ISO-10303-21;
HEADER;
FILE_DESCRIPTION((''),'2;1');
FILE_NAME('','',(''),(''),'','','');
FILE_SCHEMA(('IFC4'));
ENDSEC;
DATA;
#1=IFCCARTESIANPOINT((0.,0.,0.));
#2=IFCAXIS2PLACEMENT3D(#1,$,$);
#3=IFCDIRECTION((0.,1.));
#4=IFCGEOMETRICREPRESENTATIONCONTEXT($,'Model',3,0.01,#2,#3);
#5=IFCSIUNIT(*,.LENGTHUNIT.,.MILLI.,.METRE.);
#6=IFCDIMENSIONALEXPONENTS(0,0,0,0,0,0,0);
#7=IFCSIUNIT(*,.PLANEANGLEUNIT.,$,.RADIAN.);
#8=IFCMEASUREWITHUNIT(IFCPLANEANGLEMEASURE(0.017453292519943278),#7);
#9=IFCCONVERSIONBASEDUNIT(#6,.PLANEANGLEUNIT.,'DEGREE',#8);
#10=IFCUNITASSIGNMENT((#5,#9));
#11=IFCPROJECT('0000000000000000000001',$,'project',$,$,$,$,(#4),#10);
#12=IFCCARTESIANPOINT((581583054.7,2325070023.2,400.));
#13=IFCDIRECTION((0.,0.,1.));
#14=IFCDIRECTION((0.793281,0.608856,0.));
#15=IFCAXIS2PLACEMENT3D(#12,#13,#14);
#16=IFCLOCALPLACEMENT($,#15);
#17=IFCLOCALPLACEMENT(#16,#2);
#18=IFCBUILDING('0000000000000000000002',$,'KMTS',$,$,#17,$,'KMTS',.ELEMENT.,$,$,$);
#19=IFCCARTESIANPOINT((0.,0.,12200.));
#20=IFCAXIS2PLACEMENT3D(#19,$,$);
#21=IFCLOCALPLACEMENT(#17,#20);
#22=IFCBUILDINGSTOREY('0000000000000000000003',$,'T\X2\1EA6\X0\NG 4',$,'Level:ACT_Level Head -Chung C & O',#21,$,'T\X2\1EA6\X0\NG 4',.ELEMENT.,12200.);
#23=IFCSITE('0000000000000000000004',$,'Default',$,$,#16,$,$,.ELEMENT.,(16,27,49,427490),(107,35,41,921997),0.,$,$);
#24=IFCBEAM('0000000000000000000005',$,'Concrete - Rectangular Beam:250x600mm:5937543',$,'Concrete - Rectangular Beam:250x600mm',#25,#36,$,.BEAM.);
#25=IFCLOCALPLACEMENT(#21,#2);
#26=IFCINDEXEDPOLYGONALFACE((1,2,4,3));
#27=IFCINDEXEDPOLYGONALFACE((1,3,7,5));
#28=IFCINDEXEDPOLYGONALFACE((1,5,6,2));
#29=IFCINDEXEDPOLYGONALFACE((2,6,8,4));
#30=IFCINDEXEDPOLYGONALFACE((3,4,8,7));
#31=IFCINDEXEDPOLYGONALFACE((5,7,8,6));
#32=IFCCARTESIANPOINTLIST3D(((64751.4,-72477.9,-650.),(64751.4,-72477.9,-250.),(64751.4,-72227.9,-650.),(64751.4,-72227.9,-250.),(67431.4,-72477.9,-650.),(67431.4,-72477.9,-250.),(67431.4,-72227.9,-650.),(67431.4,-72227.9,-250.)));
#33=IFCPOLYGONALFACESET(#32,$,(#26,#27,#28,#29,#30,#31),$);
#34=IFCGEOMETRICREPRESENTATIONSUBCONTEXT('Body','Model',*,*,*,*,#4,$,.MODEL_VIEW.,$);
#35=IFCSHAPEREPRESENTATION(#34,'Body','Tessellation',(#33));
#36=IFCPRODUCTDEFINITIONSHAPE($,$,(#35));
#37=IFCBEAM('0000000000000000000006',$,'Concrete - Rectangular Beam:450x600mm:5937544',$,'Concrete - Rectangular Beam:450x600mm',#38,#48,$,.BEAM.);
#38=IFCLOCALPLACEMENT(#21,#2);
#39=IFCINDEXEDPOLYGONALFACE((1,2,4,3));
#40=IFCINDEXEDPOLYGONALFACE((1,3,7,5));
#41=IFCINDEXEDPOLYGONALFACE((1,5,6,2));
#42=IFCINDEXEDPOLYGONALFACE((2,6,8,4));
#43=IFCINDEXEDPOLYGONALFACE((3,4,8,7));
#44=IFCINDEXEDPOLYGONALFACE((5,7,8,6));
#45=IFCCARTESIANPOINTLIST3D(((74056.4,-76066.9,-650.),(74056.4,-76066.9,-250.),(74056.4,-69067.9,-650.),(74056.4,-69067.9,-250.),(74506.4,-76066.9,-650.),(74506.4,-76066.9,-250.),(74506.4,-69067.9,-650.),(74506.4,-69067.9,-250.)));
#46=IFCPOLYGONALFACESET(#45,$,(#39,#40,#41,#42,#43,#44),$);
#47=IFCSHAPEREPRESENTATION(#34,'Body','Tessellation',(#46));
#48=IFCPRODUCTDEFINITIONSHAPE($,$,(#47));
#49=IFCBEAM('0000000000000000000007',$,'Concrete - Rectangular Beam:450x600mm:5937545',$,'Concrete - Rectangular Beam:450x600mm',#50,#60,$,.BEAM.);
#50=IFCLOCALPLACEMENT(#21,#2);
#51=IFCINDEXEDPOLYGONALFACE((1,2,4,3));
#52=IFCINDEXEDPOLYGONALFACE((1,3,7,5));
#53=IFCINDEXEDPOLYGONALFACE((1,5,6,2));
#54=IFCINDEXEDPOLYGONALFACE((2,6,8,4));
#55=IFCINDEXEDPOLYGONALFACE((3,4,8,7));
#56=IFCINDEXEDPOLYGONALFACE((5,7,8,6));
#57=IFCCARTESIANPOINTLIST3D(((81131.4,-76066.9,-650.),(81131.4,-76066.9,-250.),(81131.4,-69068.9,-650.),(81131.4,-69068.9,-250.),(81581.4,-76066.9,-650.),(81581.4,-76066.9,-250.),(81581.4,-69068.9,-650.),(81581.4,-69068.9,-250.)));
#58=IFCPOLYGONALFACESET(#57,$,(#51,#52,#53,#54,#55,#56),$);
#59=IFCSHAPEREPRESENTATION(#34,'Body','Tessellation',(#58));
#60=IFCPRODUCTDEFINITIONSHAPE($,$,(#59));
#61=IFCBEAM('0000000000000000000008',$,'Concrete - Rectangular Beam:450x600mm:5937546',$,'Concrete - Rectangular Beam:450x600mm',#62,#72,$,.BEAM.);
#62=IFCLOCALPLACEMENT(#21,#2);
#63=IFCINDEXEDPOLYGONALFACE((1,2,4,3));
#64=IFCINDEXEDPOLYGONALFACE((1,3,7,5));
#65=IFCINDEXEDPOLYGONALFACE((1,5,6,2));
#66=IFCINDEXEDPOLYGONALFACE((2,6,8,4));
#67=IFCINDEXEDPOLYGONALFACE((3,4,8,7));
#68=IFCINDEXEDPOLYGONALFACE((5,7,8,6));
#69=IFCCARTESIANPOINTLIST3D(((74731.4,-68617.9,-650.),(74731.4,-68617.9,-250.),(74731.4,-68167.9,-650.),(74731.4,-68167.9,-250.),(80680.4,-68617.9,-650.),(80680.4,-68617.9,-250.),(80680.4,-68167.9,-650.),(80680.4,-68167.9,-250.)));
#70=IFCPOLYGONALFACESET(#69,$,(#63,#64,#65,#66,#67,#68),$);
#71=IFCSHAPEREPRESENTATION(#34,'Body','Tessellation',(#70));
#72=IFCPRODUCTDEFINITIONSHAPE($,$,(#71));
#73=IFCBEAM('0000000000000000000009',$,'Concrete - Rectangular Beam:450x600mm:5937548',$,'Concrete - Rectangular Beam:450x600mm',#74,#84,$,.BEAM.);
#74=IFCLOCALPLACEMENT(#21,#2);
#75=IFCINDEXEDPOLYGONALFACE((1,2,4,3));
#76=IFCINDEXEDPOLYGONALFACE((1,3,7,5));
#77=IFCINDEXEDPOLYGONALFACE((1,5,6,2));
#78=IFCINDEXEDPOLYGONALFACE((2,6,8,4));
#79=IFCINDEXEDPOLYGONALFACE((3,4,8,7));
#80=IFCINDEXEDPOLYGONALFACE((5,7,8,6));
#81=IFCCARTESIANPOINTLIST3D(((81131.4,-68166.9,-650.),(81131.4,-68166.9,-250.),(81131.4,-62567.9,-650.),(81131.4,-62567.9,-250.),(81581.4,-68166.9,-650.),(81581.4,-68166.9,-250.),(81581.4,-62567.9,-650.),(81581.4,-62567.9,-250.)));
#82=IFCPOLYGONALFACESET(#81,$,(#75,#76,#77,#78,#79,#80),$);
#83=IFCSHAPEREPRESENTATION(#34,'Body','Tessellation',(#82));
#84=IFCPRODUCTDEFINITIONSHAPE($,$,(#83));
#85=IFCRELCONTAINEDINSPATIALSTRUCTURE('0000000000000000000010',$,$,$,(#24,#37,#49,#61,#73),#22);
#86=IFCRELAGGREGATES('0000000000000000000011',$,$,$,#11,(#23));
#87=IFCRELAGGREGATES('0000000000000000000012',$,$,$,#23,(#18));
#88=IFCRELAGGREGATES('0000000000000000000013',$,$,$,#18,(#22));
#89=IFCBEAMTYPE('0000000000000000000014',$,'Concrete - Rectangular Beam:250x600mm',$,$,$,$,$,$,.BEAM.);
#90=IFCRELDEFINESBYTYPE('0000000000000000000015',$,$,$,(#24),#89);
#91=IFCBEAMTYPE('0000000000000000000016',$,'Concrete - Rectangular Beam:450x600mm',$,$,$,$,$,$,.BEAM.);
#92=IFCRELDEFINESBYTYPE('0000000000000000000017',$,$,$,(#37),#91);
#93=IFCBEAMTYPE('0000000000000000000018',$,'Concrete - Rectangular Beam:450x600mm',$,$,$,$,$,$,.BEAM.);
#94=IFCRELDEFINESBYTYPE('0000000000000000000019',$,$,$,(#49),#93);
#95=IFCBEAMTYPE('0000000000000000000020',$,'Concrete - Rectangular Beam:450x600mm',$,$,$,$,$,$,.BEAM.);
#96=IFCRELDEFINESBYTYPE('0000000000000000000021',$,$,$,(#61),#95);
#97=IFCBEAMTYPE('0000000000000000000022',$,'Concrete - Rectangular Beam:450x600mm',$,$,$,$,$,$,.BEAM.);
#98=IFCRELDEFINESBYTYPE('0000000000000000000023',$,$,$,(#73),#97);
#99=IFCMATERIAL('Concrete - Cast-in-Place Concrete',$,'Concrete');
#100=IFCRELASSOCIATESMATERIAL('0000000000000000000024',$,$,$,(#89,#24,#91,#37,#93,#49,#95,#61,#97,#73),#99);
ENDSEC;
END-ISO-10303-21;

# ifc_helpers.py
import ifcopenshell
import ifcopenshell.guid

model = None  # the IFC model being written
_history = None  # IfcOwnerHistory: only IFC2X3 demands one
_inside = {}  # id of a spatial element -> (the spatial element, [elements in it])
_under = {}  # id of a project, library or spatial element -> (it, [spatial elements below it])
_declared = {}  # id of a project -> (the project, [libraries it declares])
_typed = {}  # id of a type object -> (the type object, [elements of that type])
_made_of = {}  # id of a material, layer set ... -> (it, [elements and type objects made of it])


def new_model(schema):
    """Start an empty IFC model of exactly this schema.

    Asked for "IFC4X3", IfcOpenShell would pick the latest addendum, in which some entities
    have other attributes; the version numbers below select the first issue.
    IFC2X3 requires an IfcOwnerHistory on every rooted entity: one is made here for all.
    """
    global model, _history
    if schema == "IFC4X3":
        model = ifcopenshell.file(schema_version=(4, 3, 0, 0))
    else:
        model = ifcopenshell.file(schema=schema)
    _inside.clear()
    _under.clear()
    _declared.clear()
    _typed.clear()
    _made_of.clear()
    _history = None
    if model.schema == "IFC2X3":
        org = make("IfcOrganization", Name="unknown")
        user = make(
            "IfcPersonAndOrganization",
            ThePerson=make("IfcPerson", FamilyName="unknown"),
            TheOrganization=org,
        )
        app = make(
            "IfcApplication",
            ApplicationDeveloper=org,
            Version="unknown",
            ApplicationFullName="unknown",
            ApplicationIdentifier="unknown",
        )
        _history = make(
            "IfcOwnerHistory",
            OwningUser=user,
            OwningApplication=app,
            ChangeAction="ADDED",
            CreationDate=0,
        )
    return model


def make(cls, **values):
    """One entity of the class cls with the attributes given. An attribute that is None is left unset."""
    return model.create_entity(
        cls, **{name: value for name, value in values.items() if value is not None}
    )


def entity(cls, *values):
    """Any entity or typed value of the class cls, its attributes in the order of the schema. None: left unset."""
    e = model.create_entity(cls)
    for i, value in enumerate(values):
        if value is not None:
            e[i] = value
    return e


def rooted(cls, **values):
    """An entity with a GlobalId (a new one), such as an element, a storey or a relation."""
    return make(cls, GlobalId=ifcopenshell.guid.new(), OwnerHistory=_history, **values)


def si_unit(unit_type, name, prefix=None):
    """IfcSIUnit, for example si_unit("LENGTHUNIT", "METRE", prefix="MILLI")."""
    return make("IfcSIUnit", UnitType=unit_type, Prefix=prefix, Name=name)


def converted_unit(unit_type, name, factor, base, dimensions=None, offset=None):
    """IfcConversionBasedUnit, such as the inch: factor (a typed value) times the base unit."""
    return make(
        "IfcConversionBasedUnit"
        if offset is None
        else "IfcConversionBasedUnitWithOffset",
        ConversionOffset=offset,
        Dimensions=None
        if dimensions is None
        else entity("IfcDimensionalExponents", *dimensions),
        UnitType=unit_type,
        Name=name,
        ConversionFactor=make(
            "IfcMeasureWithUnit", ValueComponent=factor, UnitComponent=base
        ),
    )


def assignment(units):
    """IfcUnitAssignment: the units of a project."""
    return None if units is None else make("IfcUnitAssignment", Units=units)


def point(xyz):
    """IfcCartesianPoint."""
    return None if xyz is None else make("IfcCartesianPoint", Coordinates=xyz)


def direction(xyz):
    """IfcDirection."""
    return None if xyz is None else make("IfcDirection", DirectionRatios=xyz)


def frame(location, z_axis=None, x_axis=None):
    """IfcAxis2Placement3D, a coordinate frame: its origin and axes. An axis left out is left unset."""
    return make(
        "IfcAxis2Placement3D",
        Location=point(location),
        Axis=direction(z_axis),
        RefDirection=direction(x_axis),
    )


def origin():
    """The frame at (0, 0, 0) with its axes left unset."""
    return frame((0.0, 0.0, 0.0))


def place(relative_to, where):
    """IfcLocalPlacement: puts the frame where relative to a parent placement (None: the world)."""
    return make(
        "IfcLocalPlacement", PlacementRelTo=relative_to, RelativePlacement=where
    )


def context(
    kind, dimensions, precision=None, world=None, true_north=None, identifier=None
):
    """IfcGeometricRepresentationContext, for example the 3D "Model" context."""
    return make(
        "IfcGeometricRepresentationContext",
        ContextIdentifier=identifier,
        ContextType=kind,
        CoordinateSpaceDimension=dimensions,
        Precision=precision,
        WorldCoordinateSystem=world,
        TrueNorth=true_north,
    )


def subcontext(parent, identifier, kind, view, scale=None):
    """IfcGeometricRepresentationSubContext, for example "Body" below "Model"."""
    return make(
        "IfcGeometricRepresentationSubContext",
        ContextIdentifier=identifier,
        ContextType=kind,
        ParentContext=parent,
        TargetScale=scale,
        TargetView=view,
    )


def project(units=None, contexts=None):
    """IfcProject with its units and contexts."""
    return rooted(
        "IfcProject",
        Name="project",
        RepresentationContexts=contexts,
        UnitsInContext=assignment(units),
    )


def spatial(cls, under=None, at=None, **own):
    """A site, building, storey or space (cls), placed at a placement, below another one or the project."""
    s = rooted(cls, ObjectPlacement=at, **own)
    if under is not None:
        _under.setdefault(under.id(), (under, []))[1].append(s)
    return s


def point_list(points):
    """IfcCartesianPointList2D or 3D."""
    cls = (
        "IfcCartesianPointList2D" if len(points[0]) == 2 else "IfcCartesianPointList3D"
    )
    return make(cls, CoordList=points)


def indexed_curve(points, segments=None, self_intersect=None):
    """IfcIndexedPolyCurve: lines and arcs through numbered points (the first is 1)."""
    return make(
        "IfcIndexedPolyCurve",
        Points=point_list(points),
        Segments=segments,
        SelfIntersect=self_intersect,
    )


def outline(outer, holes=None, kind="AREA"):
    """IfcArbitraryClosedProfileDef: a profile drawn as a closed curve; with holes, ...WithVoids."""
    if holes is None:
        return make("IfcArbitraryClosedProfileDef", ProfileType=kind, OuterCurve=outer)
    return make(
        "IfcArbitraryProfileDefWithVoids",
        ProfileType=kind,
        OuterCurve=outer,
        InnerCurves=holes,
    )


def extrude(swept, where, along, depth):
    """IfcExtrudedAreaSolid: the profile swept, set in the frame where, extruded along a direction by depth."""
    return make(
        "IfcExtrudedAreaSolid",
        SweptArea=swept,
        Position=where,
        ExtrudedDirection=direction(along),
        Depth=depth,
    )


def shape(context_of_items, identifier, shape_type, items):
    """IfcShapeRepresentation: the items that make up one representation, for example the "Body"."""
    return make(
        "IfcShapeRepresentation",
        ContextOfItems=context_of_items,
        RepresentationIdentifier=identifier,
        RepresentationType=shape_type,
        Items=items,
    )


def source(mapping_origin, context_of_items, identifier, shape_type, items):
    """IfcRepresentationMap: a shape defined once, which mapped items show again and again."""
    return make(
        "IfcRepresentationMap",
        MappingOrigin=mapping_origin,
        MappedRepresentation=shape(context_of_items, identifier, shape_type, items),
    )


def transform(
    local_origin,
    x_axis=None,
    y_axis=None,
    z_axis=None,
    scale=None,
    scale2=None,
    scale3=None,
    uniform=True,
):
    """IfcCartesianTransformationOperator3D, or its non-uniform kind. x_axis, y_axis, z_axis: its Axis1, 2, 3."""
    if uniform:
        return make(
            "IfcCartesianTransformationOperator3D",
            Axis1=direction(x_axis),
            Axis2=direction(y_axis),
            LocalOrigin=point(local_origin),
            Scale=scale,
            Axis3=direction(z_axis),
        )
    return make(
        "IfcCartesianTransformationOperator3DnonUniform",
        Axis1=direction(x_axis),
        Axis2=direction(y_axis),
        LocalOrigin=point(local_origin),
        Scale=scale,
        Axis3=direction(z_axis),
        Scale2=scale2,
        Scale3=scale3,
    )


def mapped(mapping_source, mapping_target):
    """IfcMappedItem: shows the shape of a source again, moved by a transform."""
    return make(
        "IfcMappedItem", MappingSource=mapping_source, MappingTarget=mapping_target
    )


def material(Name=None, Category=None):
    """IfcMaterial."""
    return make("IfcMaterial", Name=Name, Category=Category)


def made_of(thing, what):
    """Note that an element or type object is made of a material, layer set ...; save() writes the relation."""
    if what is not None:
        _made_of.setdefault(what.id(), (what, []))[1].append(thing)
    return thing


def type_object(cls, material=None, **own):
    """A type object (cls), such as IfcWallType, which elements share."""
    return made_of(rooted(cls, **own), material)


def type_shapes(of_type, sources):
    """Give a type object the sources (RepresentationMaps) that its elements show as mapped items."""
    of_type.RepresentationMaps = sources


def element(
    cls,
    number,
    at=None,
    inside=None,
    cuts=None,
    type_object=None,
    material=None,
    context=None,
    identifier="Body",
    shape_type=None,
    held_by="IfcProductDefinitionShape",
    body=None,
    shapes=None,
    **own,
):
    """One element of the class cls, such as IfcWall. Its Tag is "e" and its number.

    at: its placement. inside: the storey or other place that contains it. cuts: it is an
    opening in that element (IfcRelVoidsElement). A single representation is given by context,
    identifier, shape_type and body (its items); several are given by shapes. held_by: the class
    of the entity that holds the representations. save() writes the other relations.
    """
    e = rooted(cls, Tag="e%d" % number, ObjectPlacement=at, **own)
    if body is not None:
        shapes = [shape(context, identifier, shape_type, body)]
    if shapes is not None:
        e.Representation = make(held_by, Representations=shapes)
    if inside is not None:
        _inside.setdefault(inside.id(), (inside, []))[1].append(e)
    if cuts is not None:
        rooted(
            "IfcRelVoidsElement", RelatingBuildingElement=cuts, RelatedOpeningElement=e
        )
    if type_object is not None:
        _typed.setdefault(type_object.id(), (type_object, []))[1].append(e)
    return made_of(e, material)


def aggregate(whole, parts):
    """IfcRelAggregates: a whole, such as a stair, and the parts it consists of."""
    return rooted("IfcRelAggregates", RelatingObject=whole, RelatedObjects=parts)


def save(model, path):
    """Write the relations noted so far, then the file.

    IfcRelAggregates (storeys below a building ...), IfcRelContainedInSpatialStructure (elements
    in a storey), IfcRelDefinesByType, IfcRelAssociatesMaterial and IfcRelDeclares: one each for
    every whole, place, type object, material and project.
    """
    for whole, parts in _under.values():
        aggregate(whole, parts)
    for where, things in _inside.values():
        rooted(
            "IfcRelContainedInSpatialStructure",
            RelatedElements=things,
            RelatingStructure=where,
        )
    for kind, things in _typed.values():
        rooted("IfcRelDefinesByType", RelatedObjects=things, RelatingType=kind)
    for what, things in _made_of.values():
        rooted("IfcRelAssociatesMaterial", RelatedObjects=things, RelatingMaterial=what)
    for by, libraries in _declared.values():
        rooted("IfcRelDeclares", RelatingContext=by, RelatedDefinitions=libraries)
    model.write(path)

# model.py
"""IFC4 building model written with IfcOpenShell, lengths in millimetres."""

from ifc_helpers import new_model, entity, si_unit, converted_unit, direction, frame, origin, place, context, subcontext, project, spatial, indexed_curve, outline, extrude, source, transform, mapped, material, type_object, type_shapes, element, save


model = new_model("IFC4")

# Units and contexts
model_context = context("Model", 3, precision=0.01, world=origin(), true_north=direction((0.0, 1.0)))
body_context = subcontext(model_context, "Body", "Model", "MODEL_VIEW")
ifc_project = project(units=[si_unit("LENGTHUNIT", "METRE", prefix="MILLI"), converted_unit("PLANEANGLEUNIT", "DEGREE", entity("IfcPlaneAngleMeasure", 0.017453292519943278), si_unit("PLANEANGLEUNIT", "RADIAN"), dimensions=[0, 0, 0, 0, 0, 0, 0])], contexts=[model_context])

# Site, building, storey
site_placement = place(None, frame((581583054.7, 2325070023.2, 400.0), z_axis=(0.0, 0.0, 1.0), x_axis=(0.793281, 0.608856, 0.0)))
site = spatial("IfcSite", under=ifc_project, at=site_placement, Name="Default", CompositionType="ELEMENT", RefLatitude=(16, 27, 49, 427490), RefLongitude=(107, 35, 41, 921997), RefElevation=0.0)
building_placement = place(site_placement, origin())
building = spatial("IfcBuilding", under=site, at=building_placement, Name="KMTS", LongName="KMTS", CompositionType="ELEMENT")
storey_placement = place(building_placement, frame((0.0, 0.0, 12200.0)))
storey = spatial("IfcBuildingStorey", under=building, at=storey_placement, Name="TẦNG 4", ObjectType="Level:ACT_Level Head -Chung C & O", LongName="TẦNG 4", CompositionType="ELEMENT", Elevation=12200.0)

# Beams
ifc_material_1 = material(Name="Concrete - Cast-in-Place Concrete", Category="Concrete")
beam_type_1 = type_object("IfcBeamType", Name="Concrete - Rectangular Beam:250x600mm", PredefinedType="BEAM", material=ifc_material_1)
shared_shape_1 = source(origin(), body_context, "Body", "SweptSolid", [
    extrude(outline(indexed_curve([(-200.0, -125.0), (200.0, -125.0), (200.0, 125.0), (-200.0, 125.0), (-200.0, -125.0)], self_intersect=False)), frame((64751.4, -72352.9, 11750.0), z_axis=(1.0, 0.0, 0.0), x_axis=(0.0, 0.0, -1.0)), (0.0, 0.0, 1.0), 2680.0),
])
type_shapes(beam_type_1, [shared_shape_1])
beam_1_placement = place(storey_placement, frame((0.0, 0.0, -12200.0)))
element("IfcBeam", 1, at=beam_1_placement, inside=storey, type_object=beam_type_1, material=ifc_material_1, Name="Concrete - Rectangular Beam:250x600mm:5937543", ObjectType="Concrete - Rectangular Beam:250x600mm", PredefinedType="BEAM", context=body_context, shape_type="MappedRepresentation", body=[
    mapped(shared_shape_1, transform((0.0, 0.0, 0.0), scale=1.0)),
])
beam_type_2 = type_object("IfcBeamType", Name="Concrete - Rectangular Beam:450x600mm", PredefinedType="BEAM", material=ifc_material_1)
shared_shape_2 = source(origin(), body_context, "Body", "SweptSolid", [
    extrude(outline(indexed_curve([(-225.0, -200.0), (225.0, -200.0), (225.0, 200.0), (-225.0, 200.0), (-225.0, -200.0)], self_intersect=False)), frame((74281.4, -76066.9, 11750.0), z_axis=(0.0, 1.0, 0.0), x_axis=(-1.0, 0.0, 0.0)), (0.0, 0.0, 1.0), 6999.0),
])
type_shapes(beam_type_2, [shared_shape_2])
beam_2_placement = place(storey_placement, frame((0.0, 0.0, -12200.0)))
element("IfcBeam", 2, at=beam_2_placement, inside=storey, type_object=beam_type_2, material=ifc_material_1, Name="Concrete - Rectangular Beam:450x600mm:5937544", ObjectType="Concrete - Rectangular Beam:450x600mm", PredefinedType="BEAM", context=body_context, shape_type="MappedRepresentation", body=[
    mapped(shared_shape_2, transform((0.0, 0.0, 0.0), scale=1.0)),
])
beam_type_3 = type_object("IfcBeamType", Name="Concrete - Rectangular Beam:450x600mm", PredefinedType="BEAM", material=ifc_material_1)
shared_shape_3 = source(origin(), body_context, "Body", "SweptSolid", [
    extrude(outline(indexed_curve([(-225.0, -200.0), (225.0, -200.0), (225.0, 200.0), (-225.0, 200.0), (-225.0, -200.0)], self_intersect=False)), frame((81356.4, -76066.9, 11750.0), z_axis=(0.0, 1.0, 0.0), x_axis=(-1.0, 0.0, 0.0)), (0.0, 0.0, 1.0), 6998.0),
])
type_shapes(beam_type_3, [shared_shape_3])
beam_3_placement = place(storey_placement, frame((0.0, 0.0, -12200.0)))
element("IfcBeam", 3, at=beam_3_placement, inside=storey, type_object=beam_type_3, material=ifc_material_1, Name="Concrete - Rectangular Beam:450x600mm:5937545", ObjectType="Concrete - Rectangular Beam:450x600mm", PredefinedType="BEAM", context=body_context, shape_type="MappedRepresentation", body=[
    mapped(shared_shape_3, transform((0.0, 0.0, 0.0), scale=1.0)),
])
beam_type_4 = type_object("IfcBeamType", Name="Concrete - Rectangular Beam:450x600mm", PredefinedType="BEAM", material=ifc_material_1)
shared_shape_4 = source(origin(), body_context, "Body", "SweptSolid", [
    extrude(outline(indexed_curve([(-200.0, -225.0), (200.0, -225.0), (200.0, 225.0), (-200.0, 225.0), (-200.0, -225.0)], self_intersect=False)), frame((74731.4, -68392.9, 11750.0), z_axis=(1.0, 0.0, 0.0), x_axis=(0.0, 0.0, -1.0)), (0.0, 0.0, 1.0), 5949.0),
])
type_shapes(beam_type_4, [shared_shape_4])
beam_4_placement = place(storey_placement, frame((0.0, 0.0, -12200.0)))
element("IfcBeam", 4, at=beam_4_placement, inside=storey, type_object=beam_type_4, material=ifc_material_1, Name="Concrete - Rectangular Beam:450x600mm:5937546", ObjectType="Concrete - Rectangular Beam:450x600mm", PredefinedType="BEAM", context=body_context, shape_type="MappedRepresentation", body=[
    mapped(shared_shape_4, transform((0.0, 0.0, 0.0), scale=1.0)),
])
beam_type_5 = type_object("IfcBeamType", Name="Concrete - Rectangular Beam:450x600mm", PredefinedType="BEAM", material=ifc_material_1)
shared_shape_5 = source(origin(), body_context, "Body", "SweptSolid", [
    extrude(outline(indexed_curve([(-225.0, -200.0), (225.0, -200.0), (225.0, 200.0), (-225.0, 200.0), (-225.0, -200.0)], self_intersect=False)), frame((81356.4, -68166.9, 11750.0), z_axis=(0.0, 1.0, 0.0), x_axis=(-1.0, 0.0, 0.0)), (0.0, 0.0, 1.0), 5599.0),
])
type_shapes(beam_type_5, [shared_shape_5])
beam_5_placement = place(storey_placement, frame((0.0, 0.0, -12200.0)))
element("IfcBeam", 5, at=beam_5_placement, inside=storey, type_object=beam_type_5, material=ifc_material_1, Name="Concrete - Rectangular Beam:450x600mm:5937548", ObjectType="Concrete - Rectangular Beam:450x600mm", PredefinedType="BEAM", context=body_context, shape_type="MappedRepresentation", body=[
    mapped(shared_shape_5, transform((0.0, 0.0, 0.0), scale=1.0)),
])

save(model, "model.ifc")
